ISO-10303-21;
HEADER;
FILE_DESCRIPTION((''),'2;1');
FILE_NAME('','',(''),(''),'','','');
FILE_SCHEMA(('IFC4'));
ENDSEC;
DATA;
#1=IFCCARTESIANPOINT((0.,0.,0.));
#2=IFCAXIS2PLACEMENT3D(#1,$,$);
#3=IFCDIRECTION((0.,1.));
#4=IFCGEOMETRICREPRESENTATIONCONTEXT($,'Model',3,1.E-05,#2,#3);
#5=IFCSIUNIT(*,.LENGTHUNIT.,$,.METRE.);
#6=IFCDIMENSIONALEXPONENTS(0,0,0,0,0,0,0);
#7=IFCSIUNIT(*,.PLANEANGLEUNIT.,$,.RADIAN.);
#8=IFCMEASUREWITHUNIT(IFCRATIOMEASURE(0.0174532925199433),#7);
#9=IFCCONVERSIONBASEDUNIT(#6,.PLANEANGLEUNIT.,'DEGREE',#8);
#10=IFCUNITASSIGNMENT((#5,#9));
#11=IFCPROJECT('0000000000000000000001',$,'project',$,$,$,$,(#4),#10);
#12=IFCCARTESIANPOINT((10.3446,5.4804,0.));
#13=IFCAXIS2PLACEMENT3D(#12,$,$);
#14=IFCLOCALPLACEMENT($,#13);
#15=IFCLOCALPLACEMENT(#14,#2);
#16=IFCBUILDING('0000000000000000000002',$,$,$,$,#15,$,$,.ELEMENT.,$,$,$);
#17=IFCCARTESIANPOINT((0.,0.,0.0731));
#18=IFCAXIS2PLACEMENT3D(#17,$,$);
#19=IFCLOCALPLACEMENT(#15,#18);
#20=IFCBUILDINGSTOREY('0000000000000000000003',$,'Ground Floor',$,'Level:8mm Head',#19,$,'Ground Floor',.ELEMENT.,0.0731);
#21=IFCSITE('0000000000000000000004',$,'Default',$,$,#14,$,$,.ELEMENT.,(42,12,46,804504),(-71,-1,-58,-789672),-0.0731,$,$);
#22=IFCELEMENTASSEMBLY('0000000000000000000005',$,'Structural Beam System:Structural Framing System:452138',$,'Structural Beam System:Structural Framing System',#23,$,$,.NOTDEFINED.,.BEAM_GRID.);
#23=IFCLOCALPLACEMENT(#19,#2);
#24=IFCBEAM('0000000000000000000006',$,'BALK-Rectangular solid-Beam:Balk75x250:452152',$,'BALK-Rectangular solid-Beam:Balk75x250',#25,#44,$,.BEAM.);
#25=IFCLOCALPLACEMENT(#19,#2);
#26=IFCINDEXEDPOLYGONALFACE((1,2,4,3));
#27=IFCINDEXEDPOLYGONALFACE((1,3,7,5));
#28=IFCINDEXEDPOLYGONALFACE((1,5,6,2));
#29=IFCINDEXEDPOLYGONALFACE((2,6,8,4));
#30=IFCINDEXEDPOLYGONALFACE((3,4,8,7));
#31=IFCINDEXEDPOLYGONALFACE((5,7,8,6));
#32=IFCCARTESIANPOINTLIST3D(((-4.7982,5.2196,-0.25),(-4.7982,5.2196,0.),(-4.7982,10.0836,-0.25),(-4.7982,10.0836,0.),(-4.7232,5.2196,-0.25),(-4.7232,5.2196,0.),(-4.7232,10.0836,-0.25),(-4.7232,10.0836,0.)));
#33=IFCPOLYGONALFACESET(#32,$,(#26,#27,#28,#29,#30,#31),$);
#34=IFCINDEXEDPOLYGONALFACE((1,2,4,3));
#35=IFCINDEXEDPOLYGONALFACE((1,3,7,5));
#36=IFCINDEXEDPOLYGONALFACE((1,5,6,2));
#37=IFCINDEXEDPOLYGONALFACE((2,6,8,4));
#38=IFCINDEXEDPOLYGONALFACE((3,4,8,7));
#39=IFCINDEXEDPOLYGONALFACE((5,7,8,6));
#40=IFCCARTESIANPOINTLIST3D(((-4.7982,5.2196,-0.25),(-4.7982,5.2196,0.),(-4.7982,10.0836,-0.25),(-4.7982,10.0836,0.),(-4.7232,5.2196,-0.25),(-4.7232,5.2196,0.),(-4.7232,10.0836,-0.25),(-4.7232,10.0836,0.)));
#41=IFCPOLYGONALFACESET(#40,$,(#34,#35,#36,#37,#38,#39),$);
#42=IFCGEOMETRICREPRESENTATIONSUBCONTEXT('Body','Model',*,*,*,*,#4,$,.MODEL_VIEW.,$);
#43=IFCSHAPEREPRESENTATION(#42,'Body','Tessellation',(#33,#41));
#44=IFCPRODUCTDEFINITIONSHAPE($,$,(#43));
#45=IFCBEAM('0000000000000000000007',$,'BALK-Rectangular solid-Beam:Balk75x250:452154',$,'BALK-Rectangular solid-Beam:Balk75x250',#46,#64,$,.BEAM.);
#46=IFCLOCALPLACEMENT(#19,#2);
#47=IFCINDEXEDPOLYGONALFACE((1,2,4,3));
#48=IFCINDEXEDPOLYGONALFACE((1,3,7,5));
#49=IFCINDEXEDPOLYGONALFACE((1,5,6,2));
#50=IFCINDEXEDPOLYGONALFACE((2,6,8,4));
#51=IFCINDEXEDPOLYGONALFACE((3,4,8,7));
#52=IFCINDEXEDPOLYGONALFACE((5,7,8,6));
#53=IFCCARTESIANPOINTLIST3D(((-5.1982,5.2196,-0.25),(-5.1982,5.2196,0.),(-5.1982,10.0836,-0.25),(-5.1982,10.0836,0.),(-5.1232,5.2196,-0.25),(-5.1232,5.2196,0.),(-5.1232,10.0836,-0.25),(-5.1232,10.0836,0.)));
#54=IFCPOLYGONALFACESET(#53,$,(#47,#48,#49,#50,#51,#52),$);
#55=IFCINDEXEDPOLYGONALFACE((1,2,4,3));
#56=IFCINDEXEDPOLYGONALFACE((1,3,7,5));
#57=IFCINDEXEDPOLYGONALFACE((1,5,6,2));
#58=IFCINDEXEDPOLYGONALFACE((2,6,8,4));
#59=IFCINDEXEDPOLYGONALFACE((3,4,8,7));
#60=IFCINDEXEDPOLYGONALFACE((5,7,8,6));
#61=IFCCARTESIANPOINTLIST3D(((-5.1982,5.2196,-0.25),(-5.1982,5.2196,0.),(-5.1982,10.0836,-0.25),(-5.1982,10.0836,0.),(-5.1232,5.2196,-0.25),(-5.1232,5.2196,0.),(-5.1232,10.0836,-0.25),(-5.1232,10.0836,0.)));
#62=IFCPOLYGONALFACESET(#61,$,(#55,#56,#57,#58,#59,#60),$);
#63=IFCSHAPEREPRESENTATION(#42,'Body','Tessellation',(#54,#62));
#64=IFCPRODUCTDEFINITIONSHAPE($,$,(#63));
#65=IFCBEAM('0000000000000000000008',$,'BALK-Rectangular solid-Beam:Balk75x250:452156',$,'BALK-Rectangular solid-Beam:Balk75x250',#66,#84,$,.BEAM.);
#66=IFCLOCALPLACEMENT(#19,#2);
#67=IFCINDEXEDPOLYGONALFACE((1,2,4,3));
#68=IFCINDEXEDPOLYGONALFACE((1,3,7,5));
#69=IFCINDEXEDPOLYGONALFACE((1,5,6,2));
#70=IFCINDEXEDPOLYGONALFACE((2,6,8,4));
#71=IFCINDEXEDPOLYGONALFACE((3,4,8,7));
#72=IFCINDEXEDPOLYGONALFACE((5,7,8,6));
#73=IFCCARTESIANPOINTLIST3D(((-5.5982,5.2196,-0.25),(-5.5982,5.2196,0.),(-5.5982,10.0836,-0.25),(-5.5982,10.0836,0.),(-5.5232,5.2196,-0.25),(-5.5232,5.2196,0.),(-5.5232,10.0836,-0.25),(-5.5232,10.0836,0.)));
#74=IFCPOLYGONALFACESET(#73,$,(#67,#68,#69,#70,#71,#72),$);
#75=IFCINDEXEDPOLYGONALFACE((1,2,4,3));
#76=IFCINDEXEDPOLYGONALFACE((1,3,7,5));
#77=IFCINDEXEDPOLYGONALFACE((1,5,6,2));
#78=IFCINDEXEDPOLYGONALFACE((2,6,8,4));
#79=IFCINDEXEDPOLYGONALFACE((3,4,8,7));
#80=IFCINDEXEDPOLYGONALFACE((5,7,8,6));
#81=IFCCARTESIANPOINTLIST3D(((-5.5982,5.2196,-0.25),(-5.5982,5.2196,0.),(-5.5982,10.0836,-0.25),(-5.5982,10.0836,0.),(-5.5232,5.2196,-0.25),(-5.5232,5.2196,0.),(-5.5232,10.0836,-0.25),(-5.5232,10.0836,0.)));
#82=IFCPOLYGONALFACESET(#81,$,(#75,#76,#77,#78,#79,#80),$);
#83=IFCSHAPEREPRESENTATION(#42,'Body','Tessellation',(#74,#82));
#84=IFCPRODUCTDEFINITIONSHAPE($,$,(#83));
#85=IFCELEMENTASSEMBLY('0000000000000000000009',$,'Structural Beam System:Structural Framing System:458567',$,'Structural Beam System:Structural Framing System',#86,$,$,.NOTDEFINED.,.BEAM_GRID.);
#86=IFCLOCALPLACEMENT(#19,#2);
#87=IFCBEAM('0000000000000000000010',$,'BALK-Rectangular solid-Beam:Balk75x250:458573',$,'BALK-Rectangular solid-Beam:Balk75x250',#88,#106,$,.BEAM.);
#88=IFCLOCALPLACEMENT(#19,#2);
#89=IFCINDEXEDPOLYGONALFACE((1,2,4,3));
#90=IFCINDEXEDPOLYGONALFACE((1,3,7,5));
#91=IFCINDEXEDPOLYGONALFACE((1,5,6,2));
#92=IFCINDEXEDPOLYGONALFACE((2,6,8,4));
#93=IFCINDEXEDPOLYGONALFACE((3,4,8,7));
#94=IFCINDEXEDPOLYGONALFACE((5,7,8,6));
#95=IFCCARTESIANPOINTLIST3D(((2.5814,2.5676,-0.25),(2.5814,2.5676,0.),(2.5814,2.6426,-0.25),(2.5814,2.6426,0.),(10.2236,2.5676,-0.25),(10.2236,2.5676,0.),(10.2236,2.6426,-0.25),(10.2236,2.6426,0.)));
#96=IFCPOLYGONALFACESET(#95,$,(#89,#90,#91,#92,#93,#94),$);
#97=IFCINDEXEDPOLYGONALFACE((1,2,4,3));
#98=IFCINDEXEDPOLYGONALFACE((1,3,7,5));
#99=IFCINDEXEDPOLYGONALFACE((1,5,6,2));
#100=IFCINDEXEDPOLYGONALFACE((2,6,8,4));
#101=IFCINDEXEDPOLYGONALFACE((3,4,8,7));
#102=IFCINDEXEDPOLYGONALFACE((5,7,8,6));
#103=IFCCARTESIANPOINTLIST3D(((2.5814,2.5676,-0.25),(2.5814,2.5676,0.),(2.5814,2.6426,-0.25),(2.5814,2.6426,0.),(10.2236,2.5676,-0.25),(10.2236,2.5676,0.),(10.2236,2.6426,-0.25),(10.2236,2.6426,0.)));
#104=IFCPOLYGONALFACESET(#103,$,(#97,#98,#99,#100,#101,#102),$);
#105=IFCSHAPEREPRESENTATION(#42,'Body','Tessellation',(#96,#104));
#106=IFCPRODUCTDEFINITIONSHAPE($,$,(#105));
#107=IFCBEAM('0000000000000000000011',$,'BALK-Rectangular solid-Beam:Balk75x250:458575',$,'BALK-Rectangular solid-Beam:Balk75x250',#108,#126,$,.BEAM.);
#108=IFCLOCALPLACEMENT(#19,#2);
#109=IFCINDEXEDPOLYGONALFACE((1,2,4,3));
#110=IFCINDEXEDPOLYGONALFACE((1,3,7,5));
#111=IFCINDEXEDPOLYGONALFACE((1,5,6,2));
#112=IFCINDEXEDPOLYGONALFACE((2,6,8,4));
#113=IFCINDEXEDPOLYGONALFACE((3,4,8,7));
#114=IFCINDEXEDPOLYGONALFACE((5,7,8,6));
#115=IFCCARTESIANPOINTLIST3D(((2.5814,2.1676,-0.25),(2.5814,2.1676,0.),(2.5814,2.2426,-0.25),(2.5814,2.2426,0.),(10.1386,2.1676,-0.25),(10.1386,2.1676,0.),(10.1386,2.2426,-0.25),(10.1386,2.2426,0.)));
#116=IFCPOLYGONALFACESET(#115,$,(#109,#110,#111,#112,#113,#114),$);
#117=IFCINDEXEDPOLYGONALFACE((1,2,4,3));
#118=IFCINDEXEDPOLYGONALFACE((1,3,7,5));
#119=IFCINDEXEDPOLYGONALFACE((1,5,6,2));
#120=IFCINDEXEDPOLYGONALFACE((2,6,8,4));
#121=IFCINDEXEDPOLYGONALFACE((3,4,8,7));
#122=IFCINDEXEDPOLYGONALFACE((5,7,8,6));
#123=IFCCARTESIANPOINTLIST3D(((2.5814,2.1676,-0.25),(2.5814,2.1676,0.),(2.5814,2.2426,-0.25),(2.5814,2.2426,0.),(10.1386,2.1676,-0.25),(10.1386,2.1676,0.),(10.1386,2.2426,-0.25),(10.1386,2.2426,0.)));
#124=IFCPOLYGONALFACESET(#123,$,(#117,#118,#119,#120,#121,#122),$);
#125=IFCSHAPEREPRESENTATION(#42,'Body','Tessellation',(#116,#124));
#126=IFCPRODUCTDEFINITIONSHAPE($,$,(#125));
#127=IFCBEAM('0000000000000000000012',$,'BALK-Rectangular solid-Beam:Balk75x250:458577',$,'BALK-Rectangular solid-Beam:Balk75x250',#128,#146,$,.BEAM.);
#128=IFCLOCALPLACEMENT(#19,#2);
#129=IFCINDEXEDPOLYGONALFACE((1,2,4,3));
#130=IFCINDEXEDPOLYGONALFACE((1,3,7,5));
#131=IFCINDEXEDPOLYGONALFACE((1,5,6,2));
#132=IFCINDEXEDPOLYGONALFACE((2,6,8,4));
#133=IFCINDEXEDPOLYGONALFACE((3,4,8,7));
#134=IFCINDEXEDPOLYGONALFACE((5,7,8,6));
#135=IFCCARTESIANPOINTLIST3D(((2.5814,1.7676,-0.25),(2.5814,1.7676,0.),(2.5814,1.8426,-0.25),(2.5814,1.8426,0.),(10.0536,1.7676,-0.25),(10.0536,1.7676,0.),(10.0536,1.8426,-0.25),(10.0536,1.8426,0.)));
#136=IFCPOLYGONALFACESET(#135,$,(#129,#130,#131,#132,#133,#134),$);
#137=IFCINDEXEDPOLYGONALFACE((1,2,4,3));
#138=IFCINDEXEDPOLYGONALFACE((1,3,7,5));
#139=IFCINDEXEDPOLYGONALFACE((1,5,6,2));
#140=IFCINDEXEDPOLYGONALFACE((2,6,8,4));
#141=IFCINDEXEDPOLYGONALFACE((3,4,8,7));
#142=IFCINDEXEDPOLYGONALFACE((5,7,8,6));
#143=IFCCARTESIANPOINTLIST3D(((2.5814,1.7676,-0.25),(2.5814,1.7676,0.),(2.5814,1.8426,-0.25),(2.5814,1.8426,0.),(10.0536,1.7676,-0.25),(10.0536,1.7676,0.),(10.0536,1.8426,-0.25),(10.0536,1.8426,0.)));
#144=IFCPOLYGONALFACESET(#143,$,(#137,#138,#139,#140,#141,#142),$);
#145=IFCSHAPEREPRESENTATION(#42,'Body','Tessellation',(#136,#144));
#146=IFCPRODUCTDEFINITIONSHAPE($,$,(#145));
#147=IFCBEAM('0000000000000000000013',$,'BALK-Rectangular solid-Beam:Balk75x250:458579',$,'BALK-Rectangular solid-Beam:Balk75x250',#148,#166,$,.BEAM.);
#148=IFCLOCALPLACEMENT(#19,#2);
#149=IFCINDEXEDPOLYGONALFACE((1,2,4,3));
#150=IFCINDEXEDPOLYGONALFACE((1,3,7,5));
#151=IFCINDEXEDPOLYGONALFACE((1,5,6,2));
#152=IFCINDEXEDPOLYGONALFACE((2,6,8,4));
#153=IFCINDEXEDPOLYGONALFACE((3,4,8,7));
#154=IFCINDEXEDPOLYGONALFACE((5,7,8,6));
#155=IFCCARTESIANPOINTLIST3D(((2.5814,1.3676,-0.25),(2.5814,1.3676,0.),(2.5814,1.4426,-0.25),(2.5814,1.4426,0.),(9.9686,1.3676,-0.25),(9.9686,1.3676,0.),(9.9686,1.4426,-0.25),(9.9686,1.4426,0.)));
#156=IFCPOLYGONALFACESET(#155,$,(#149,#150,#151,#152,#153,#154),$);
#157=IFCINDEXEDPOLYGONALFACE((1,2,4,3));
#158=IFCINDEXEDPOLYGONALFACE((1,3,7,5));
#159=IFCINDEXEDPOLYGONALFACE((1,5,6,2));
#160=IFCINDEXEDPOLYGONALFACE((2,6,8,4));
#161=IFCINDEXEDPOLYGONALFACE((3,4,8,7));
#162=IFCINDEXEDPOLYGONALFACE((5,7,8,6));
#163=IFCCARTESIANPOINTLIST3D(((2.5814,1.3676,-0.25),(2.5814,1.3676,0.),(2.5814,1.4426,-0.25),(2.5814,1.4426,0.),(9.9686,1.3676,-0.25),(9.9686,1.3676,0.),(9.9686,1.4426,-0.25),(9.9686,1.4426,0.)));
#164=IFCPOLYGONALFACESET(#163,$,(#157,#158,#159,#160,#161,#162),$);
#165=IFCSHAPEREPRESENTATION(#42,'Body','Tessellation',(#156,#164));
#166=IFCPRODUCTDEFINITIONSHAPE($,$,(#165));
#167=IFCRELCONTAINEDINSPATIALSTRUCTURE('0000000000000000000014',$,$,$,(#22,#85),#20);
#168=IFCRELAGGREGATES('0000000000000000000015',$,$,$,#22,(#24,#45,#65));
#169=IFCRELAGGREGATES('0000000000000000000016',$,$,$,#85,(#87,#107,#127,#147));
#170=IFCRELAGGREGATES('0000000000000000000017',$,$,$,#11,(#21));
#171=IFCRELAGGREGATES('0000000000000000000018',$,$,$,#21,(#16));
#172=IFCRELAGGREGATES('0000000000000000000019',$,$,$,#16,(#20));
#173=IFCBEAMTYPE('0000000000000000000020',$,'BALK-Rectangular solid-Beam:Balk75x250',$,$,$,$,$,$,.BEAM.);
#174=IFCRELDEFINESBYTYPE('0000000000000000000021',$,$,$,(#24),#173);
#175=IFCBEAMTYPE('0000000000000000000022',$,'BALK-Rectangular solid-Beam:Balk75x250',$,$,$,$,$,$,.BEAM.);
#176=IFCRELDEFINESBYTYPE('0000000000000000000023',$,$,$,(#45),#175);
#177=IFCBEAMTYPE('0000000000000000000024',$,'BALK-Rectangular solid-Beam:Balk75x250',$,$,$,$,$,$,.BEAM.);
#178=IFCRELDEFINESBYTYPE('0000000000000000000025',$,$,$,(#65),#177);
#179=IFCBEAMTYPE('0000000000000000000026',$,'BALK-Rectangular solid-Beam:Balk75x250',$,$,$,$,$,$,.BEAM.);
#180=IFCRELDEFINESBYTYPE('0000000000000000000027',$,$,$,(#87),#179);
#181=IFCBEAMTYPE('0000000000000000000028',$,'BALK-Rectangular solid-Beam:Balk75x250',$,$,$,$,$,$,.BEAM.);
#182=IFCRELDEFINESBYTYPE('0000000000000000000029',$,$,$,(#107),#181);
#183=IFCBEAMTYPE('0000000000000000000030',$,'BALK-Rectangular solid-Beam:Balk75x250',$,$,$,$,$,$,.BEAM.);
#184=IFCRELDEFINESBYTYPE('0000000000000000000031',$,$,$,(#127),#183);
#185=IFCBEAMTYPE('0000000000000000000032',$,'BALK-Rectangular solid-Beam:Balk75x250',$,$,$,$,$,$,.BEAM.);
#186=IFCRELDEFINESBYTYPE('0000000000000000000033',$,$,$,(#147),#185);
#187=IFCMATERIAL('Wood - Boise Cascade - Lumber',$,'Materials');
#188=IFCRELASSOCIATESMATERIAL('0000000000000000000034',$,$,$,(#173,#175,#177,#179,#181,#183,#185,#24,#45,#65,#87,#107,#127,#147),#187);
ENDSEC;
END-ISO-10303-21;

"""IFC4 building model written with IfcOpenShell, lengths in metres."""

from ifc_helpers import new_model, entity, si_unit, converted_unit, direction, frame, frame_2d, origin, place, context, subcontext, project, spatial, rectangle, extrude, source, transform, mapped, material, material_profile, profile_set, profile_usage, type_object, type_shapes, element, aggregate, save


model = new_model("IFC4")

# Units and contexts
model_context = context("Model", 3, precision=1e-05, world=origin(), true_north=direction((0.0, 1.0)))
body_context = subcontext(model_context, "Body", "Model", "MODEL_VIEW")
ifc_project = project(units=[si_unit("LENGTHUNIT", "METRE"), converted_unit("PLANEANGLEUNIT", "DEGREE", entity("IfcRatioMeasure", 0.0174532925199433), si_unit("PLANEANGLEUNIT", "RADIAN"), dimensions=[0, 0, 0, 0, 0, 0, 0])], contexts=[model_context])

# Site, building, storey
site_placement = place(None, frame((10.3446, 5.4804, 0.0)))
site = spatial("IfcSite", under=ifc_project, at=site_placement, Name="Default", CompositionType="ELEMENT", RefLatitude=(42, 12, 46, 804504), RefLongitude=(-71, -1, -58, -789672), RefElevation=-0.0731)
building_placement = place(site_placement, origin())
building = spatial("IfcBuilding", under=site, at=building_placement, CompositionType="ELEMENT")
storey_placement = place(building_placement, frame((0.0, 0.0, 0.0731)))
storey = spatial("IfcBuildingStorey", under=building, at=storey_placement, Name="Ground Floor", ObjectType="Level:8mm Head", LongName="Ground Floor", CompositionType="ELEMENT", Elevation=0.0731)

# Element assemblies, beams
ifc_material_1 = material(Name="Wood - Boise Cascade - Lumber", Category="Materials")
ifc_material_profile = material_profile(ifc_material_1, rectangle(XDim=0.25, YDim=0.075, at=frame_2d((0.0, 0.0), x_axis=(1.0, 0.0))), Name="Balk75x250")
ifc_profile_set = profile_set([ifc_material_profile], Name="Balk75x250")
assembly_1_placement = place(storey_placement, origin())
assembly_1 = element("IfcElementAssembly", 1, at=assembly_1_placement, inside=storey, Name="Structural Beam System:Structural Framing System:452138", ObjectType="Structural Beam System:Structural Framing System", AssemblyPlace="NOTDEFINED", PredefinedType="BEAM_GRID")
ifc_profile_usage_1 = profile_usage(ifc_profile_set, cardinal=8)
beam_type_1 = type_object("IfcBeamType", Name="BALK-Rectangular solid-Beam:Balk75x250", PredefinedType="BEAM", material=ifc_profile_set)
shared_shape_1 = source(origin(), body_context, "Body", "SweptSolid", [
    extrude(rectangle(XDim=0.25, YDim=0.075, at=frame_2d((0.0, 0.0), x_axis=(0.0, 1.0))), frame((-4.7607, 10.0836, -0.0519), z_axis=(0.0, -1.0, 0.0), x_axis=(-1.0, 0.0, 0.0)), (0.0, 0.0, 1.0), 4.864),
    extrude(rectangle(XDim=0.25, YDim=0.075, at=frame_2d((0.0, 0.0), x_axis=(0.0, 1.0))), frame((-4.7607, 10.0836, -0.0519), z_axis=(0.0, -1.0, 0.0), x_axis=(-1.0, 0.0, 0.0)), (0.0, 0.0, 1.0), 4.864),
])
type_shapes(beam_type_1, [shared_shape_1])
beam_1_placement = place(assembly_1_placement, frame((0.0, 0.0, -0.0731)))
beam_1 = element("IfcBeam", 2, at=beam_1_placement, type_object=beam_type_1, material=ifc_profile_usage_1, Name="BALK-Rectangular solid-Beam:Balk75x250:452152", ObjectType="BALK-Rectangular solid-Beam:Balk75x250", PredefinedType="BEAM", context=body_context, shape_type="MappedRepresentation", body=[
    mapped(shared_shape_1, transform((0.0, 0.0, 0.0), scale=1.0)),
])
ifc_profile_usage_2 = profile_usage(ifc_profile_set, cardinal=8)
beam_type_2 = type_object("IfcBeamType", Name="BALK-Rectangular solid-Beam:Balk75x250", PredefinedType="BEAM", material=ifc_profile_set)
shared_shape_2 = source(origin(), body_context, "Body", "SweptSolid", [
    extrude(rectangle(XDim=0.25, YDim=0.075, at=frame_2d((0.0, 0.0), x_axis=(0.0, 1.0))), frame((-5.1607, 10.0836, -0.0519), z_axis=(0.0, -1.0, 0.0), x_axis=(-1.0, 0.0, 0.0)), (0.0, 0.0, 1.0), 4.864),
    extrude(rectangle(XDim=0.25, YDim=0.075, at=frame_2d((0.0, 0.0), x_axis=(0.0, 1.0))), frame((-5.1607, 10.0836, -0.0519), z_axis=(0.0, -1.0, 0.0), x_axis=(-1.0, 0.0, 0.0)), (0.0, 0.0, 1.0), 4.864),
])
type_shapes(beam_type_2, [shared_shape_2])
beam_2_placement = place(assembly_1_placement, frame((0.0, 0.0, -0.0731)))
beam_2 = element("IfcBeam", 3, at=beam_2_placement, type_object=beam_type_2, material=ifc_profile_usage_2, Name="BALK-Rectangular solid-Beam:Balk75x250:452154", ObjectType="BALK-Rectangular solid-Beam:Balk75x250", PredefinedType="BEAM", context=body_context, shape_type="MappedRepresentation", body=[
    mapped(shared_shape_2, transform((0.0, 0.0, 0.0), scale=1.0)),
])
ifc_profile_usage_3 = profile_usage(ifc_profile_set, cardinal=8)
beam_type_3 = type_object("IfcBeamType", Name="BALK-Rectangular solid-Beam:Balk75x250", PredefinedType="BEAM", material=ifc_profile_set)
shared_shape_3 = source(origin(), body_context, "Body", "SweptSolid", [
    extrude(rectangle(XDim=0.25, YDim=0.075, at=frame_2d((0.0, 0.0), x_axis=(0.0, 1.0))), frame((-5.5607, 10.0836, -0.0519), z_axis=(0.0, -1.0, 0.0), x_axis=(-1.0, 0.0, 0.0)), (0.0, 0.0, 1.0), 4.864),
    extrude(rectangle(XDim=0.25, YDim=0.075, at=frame_2d((0.0, 0.0), x_axis=(0.0, 1.0))), frame((-5.5607, 10.0836, -0.0519), z_axis=(0.0, -1.0, 0.0), x_axis=(-1.0, 0.0, 0.0)), (0.0, 0.0, 1.0), 4.864),
])
type_shapes(beam_type_3, [shared_shape_3])
beam_3_placement = place(assembly_1_placement, frame((0.0, 0.0, -0.0731)))
beam_3 = element("IfcBeam", 4, at=beam_3_placement, type_object=beam_type_3, material=ifc_profile_usage_3, Name="BALK-Rectangular solid-Beam:Balk75x250:452156", ObjectType="BALK-Rectangular solid-Beam:Balk75x250", PredefinedType="BEAM", context=body_context, shape_type="MappedRepresentation", body=[
    mapped(shared_shape_3, transform((0.0, 0.0, 0.0), scale=1.0)),
])
aggregate(assembly_1, [beam_1, beam_2, beam_3])
assembly_2_placement = place(storey_placement, origin())
assembly_2 = element("IfcElementAssembly", 5, at=assembly_2_placement, inside=storey, Name="Structural Beam System:Structural Framing System:458567", ObjectType="Structural Beam System:Structural Framing System", AssemblyPlace="NOTDEFINED", PredefinedType="BEAM_GRID")
ifc_profile_usage_4 = profile_usage(ifc_profile_set, cardinal=8)
beam_type_4 = type_object("IfcBeamType", Name="BALK-Rectangular solid-Beam:Balk75x250", PredefinedType="BEAM", material=ifc_profile_set)
shared_shape_4 = source(origin(), body_context, "Body", "SweptSolid", [
    extrude(rectangle(XDim=0.25, YDim=0.075, at=frame_2d((0.0, 0.0), x_axis=(1.0, 0.0))), frame((2.5814, 2.6051, -0.0519), z_axis=(1.0, 0.0, 0.0), x_axis=(0.0, 0.0, -1.0)), (0.0, 0.0, 1.0), 7.6423),
    extrude(rectangle(XDim=0.25, YDim=0.075, at=frame_2d((0.0, 0.0), x_axis=(1.0, 0.0))), frame((2.5814, 2.6051, -0.0519), z_axis=(1.0, 0.0, 0.0), x_axis=(0.0, 0.0, -1.0)), (0.0, 0.0, 1.0), 7.6423),
])
type_shapes(beam_type_4, [shared_shape_4])
beam_4_placement = place(assembly_2_placement, frame((0.0, 0.0, -0.0731)))
beam_4 = element("IfcBeam", 6, at=beam_4_placement, type_object=beam_type_4, material=ifc_profile_usage_4, Name="BALK-Rectangular solid-Beam:Balk75x250:458573", ObjectType="BALK-Rectangular solid-Beam:Balk75x250", PredefinedType="BEAM", context=body_context, shape_type="MappedRepresentation", body=[
    mapped(shared_shape_4, transform((0.0, 0.0, 0.0), scale=1.0)),
])
ifc_profile_usage_5 = profile_usage(ifc_profile_set, cardinal=8)
beam_type_5 = type_object("IfcBeamType", Name="BALK-Rectangular solid-Beam:Balk75x250", PredefinedType="BEAM", material=ifc_profile_set)
shared_shape_5 = source(origin(), body_context, "Body", "SweptSolid", [
    extrude(rectangle(XDim=0.25, YDim=0.075, at=frame_2d((0.0, 0.0), x_axis=(1.0, 0.0))), frame((2.5814, 2.2051, -0.0519), z_axis=(1.0, 0.0, 0.0), x_axis=(0.0, 0.0, -1.0)), (0.0, 0.0, 1.0), 7.5573),
    extrude(rectangle(XDim=0.25, YDim=0.075, at=frame_2d((0.0, 0.0), x_axis=(1.0, 0.0))), frame((2.5814, 2.2051, -0.0519), z_axis=(1.0, 0.0, 0.0), x_axis=(0.0, 0.0, -1.0)), (0.0, 0.0, 1.0), 7.5573),
])
type_shapes(beam_type_5, [shared_shape_5])
beam_5_placement = place(assembly_2_placement, frame((0.0, 0.0, -0.0731)))
beam_5 = element("IfcBeam", 7, at=beam_5_placement, type_object=beam_type_5, material=ifc_profile_usage_5, Name="BALK-Rectangular solid-Beam:Balk75x250:458575", ObjectType="BALK-Rectangular solid-Beam:Balk75x250", PredefinedType="BEAM", context=body_context, shape_type="MappedRepresentation", body=[
    mapped(shared_shape_5, transform((0.0, 0.0, 0.0), scale=1.0)),
])
ifc_profile_usage_6 = profile_usage(ifc_profile_set, cardinal=8)
beam_type_6 = type_object("IfcBeamType", Name="BALK-Rectangular solid-Beam:Balk75x250", PredefinedType="BEAM", material=ifc_profile_set)
shared_shape_6 = source(origin(), body_context, "Body", "SweptSolid", [
    extrude(rectangle(XDim=0.25, YDim=0.075, at=frame_2d((0.0, 0.0), x_axis=(1.0, 0.0))), frame((2.5814, 1.8051, -0.0519), z_axis=(1.0, 0.0, 0.0), x_axis=(0.0, 0.0, -1.0)), (0.0, 0.0, 1.0), 7.4722),
    extrude(rectangle(XDim=0.25, YDim=0.075, at=frame_2d((0.0, 0.0), x_axis=(1.0, 0.0))), frame((2.5814, 1.8051, -0.0519), z_axis=(1.0, 0.0, 0.0), x_axis=(0.0, 0.0, -1.0)), (0.0, 0.0, 1.0), 7.4722),
])
type_shapes(beam_type_6, [shared_shape_6])
beam_6_placement = place(assembly_2_placement, frame((0.0, 0.0, -0.0731)))
beam_6 = element("IfcBeam", 8, at=beam_6_placement, type_object=beam_type_6, material=ifc_profile_usage_6, Name="BALK-Rectangular solid-Beam:Balk75x250:458577", ObjectType="BALK-Rectangular solid-Beam:Balk75x250", PredefinedType="BEAM", context=body_context, shape_type="MappedRepresentation", body=[
    mapped(shared_shape_6, transform((0.0, 0.0, 0.0), scale=1.0)),
])
ifc_profile_usage_7 = profile_usage(ifc_profile_set, cardinal=8)
beam_type_7 = type_object("IfcBeamType", Name="BALK-Rectangular solid-Beam:Balk75x250", PredefinedType="BEAM", material=ifc_profile_set)
shared_shape_7 = source(origin(), body_context, "Body", "SweptSolid", [
    extrude(rectangle(XDim=0.25, YDim=0.075, at=frame_2d((0.0, 0.0), x_axis=(1.0, 0.0))), frame((2.5814, 1.4051, -0.0519), z_axis=(1.0, 0.0, 0.0), x_axis=(0.0, 0.0, -1.0)), (0.0, 0.0, 1.0), 7.3872),
    extrude(rectangle(XDim=0.25, YDim=0.075, at=frame_2d((0.0, 0.0), x_axis=(1.0, 0.0))), frame((2.5814, 1.4051, -0.0519), z_axis=(1.0, 0.0, 0.0), x_axis=(0.0, 0.0, -1.0)), (0.0, 0.0, 1.0), 7.3872),
])
type_shapes(beam_type_7, [shared_shape_7])
beam_7_placement = place(assembly_2_placement, frame((0.0, 0.0, -0.0731)))
beam_7 = element("IfcBeam", 9, at=beam_7_placement, type_object=beam_type_7, material=ifc_profile_usage_7, Name="BALK-Rectangular solid-Beam:Balk75x250:458579", ObjectType="BALK-Rectangular solid-Beam:Balk75x250", PredefinedType="BEAM", context=body_context, shape_type="MappedRepresentation", body=[
    mapped(shared_shape_7, transform((0.0, 0.0, 0.0), scale=1.0)),
])
aggregate(assembly_2, [beam_4, beam_5, beam_6, beam_7])

save(model, "model.ifc")
